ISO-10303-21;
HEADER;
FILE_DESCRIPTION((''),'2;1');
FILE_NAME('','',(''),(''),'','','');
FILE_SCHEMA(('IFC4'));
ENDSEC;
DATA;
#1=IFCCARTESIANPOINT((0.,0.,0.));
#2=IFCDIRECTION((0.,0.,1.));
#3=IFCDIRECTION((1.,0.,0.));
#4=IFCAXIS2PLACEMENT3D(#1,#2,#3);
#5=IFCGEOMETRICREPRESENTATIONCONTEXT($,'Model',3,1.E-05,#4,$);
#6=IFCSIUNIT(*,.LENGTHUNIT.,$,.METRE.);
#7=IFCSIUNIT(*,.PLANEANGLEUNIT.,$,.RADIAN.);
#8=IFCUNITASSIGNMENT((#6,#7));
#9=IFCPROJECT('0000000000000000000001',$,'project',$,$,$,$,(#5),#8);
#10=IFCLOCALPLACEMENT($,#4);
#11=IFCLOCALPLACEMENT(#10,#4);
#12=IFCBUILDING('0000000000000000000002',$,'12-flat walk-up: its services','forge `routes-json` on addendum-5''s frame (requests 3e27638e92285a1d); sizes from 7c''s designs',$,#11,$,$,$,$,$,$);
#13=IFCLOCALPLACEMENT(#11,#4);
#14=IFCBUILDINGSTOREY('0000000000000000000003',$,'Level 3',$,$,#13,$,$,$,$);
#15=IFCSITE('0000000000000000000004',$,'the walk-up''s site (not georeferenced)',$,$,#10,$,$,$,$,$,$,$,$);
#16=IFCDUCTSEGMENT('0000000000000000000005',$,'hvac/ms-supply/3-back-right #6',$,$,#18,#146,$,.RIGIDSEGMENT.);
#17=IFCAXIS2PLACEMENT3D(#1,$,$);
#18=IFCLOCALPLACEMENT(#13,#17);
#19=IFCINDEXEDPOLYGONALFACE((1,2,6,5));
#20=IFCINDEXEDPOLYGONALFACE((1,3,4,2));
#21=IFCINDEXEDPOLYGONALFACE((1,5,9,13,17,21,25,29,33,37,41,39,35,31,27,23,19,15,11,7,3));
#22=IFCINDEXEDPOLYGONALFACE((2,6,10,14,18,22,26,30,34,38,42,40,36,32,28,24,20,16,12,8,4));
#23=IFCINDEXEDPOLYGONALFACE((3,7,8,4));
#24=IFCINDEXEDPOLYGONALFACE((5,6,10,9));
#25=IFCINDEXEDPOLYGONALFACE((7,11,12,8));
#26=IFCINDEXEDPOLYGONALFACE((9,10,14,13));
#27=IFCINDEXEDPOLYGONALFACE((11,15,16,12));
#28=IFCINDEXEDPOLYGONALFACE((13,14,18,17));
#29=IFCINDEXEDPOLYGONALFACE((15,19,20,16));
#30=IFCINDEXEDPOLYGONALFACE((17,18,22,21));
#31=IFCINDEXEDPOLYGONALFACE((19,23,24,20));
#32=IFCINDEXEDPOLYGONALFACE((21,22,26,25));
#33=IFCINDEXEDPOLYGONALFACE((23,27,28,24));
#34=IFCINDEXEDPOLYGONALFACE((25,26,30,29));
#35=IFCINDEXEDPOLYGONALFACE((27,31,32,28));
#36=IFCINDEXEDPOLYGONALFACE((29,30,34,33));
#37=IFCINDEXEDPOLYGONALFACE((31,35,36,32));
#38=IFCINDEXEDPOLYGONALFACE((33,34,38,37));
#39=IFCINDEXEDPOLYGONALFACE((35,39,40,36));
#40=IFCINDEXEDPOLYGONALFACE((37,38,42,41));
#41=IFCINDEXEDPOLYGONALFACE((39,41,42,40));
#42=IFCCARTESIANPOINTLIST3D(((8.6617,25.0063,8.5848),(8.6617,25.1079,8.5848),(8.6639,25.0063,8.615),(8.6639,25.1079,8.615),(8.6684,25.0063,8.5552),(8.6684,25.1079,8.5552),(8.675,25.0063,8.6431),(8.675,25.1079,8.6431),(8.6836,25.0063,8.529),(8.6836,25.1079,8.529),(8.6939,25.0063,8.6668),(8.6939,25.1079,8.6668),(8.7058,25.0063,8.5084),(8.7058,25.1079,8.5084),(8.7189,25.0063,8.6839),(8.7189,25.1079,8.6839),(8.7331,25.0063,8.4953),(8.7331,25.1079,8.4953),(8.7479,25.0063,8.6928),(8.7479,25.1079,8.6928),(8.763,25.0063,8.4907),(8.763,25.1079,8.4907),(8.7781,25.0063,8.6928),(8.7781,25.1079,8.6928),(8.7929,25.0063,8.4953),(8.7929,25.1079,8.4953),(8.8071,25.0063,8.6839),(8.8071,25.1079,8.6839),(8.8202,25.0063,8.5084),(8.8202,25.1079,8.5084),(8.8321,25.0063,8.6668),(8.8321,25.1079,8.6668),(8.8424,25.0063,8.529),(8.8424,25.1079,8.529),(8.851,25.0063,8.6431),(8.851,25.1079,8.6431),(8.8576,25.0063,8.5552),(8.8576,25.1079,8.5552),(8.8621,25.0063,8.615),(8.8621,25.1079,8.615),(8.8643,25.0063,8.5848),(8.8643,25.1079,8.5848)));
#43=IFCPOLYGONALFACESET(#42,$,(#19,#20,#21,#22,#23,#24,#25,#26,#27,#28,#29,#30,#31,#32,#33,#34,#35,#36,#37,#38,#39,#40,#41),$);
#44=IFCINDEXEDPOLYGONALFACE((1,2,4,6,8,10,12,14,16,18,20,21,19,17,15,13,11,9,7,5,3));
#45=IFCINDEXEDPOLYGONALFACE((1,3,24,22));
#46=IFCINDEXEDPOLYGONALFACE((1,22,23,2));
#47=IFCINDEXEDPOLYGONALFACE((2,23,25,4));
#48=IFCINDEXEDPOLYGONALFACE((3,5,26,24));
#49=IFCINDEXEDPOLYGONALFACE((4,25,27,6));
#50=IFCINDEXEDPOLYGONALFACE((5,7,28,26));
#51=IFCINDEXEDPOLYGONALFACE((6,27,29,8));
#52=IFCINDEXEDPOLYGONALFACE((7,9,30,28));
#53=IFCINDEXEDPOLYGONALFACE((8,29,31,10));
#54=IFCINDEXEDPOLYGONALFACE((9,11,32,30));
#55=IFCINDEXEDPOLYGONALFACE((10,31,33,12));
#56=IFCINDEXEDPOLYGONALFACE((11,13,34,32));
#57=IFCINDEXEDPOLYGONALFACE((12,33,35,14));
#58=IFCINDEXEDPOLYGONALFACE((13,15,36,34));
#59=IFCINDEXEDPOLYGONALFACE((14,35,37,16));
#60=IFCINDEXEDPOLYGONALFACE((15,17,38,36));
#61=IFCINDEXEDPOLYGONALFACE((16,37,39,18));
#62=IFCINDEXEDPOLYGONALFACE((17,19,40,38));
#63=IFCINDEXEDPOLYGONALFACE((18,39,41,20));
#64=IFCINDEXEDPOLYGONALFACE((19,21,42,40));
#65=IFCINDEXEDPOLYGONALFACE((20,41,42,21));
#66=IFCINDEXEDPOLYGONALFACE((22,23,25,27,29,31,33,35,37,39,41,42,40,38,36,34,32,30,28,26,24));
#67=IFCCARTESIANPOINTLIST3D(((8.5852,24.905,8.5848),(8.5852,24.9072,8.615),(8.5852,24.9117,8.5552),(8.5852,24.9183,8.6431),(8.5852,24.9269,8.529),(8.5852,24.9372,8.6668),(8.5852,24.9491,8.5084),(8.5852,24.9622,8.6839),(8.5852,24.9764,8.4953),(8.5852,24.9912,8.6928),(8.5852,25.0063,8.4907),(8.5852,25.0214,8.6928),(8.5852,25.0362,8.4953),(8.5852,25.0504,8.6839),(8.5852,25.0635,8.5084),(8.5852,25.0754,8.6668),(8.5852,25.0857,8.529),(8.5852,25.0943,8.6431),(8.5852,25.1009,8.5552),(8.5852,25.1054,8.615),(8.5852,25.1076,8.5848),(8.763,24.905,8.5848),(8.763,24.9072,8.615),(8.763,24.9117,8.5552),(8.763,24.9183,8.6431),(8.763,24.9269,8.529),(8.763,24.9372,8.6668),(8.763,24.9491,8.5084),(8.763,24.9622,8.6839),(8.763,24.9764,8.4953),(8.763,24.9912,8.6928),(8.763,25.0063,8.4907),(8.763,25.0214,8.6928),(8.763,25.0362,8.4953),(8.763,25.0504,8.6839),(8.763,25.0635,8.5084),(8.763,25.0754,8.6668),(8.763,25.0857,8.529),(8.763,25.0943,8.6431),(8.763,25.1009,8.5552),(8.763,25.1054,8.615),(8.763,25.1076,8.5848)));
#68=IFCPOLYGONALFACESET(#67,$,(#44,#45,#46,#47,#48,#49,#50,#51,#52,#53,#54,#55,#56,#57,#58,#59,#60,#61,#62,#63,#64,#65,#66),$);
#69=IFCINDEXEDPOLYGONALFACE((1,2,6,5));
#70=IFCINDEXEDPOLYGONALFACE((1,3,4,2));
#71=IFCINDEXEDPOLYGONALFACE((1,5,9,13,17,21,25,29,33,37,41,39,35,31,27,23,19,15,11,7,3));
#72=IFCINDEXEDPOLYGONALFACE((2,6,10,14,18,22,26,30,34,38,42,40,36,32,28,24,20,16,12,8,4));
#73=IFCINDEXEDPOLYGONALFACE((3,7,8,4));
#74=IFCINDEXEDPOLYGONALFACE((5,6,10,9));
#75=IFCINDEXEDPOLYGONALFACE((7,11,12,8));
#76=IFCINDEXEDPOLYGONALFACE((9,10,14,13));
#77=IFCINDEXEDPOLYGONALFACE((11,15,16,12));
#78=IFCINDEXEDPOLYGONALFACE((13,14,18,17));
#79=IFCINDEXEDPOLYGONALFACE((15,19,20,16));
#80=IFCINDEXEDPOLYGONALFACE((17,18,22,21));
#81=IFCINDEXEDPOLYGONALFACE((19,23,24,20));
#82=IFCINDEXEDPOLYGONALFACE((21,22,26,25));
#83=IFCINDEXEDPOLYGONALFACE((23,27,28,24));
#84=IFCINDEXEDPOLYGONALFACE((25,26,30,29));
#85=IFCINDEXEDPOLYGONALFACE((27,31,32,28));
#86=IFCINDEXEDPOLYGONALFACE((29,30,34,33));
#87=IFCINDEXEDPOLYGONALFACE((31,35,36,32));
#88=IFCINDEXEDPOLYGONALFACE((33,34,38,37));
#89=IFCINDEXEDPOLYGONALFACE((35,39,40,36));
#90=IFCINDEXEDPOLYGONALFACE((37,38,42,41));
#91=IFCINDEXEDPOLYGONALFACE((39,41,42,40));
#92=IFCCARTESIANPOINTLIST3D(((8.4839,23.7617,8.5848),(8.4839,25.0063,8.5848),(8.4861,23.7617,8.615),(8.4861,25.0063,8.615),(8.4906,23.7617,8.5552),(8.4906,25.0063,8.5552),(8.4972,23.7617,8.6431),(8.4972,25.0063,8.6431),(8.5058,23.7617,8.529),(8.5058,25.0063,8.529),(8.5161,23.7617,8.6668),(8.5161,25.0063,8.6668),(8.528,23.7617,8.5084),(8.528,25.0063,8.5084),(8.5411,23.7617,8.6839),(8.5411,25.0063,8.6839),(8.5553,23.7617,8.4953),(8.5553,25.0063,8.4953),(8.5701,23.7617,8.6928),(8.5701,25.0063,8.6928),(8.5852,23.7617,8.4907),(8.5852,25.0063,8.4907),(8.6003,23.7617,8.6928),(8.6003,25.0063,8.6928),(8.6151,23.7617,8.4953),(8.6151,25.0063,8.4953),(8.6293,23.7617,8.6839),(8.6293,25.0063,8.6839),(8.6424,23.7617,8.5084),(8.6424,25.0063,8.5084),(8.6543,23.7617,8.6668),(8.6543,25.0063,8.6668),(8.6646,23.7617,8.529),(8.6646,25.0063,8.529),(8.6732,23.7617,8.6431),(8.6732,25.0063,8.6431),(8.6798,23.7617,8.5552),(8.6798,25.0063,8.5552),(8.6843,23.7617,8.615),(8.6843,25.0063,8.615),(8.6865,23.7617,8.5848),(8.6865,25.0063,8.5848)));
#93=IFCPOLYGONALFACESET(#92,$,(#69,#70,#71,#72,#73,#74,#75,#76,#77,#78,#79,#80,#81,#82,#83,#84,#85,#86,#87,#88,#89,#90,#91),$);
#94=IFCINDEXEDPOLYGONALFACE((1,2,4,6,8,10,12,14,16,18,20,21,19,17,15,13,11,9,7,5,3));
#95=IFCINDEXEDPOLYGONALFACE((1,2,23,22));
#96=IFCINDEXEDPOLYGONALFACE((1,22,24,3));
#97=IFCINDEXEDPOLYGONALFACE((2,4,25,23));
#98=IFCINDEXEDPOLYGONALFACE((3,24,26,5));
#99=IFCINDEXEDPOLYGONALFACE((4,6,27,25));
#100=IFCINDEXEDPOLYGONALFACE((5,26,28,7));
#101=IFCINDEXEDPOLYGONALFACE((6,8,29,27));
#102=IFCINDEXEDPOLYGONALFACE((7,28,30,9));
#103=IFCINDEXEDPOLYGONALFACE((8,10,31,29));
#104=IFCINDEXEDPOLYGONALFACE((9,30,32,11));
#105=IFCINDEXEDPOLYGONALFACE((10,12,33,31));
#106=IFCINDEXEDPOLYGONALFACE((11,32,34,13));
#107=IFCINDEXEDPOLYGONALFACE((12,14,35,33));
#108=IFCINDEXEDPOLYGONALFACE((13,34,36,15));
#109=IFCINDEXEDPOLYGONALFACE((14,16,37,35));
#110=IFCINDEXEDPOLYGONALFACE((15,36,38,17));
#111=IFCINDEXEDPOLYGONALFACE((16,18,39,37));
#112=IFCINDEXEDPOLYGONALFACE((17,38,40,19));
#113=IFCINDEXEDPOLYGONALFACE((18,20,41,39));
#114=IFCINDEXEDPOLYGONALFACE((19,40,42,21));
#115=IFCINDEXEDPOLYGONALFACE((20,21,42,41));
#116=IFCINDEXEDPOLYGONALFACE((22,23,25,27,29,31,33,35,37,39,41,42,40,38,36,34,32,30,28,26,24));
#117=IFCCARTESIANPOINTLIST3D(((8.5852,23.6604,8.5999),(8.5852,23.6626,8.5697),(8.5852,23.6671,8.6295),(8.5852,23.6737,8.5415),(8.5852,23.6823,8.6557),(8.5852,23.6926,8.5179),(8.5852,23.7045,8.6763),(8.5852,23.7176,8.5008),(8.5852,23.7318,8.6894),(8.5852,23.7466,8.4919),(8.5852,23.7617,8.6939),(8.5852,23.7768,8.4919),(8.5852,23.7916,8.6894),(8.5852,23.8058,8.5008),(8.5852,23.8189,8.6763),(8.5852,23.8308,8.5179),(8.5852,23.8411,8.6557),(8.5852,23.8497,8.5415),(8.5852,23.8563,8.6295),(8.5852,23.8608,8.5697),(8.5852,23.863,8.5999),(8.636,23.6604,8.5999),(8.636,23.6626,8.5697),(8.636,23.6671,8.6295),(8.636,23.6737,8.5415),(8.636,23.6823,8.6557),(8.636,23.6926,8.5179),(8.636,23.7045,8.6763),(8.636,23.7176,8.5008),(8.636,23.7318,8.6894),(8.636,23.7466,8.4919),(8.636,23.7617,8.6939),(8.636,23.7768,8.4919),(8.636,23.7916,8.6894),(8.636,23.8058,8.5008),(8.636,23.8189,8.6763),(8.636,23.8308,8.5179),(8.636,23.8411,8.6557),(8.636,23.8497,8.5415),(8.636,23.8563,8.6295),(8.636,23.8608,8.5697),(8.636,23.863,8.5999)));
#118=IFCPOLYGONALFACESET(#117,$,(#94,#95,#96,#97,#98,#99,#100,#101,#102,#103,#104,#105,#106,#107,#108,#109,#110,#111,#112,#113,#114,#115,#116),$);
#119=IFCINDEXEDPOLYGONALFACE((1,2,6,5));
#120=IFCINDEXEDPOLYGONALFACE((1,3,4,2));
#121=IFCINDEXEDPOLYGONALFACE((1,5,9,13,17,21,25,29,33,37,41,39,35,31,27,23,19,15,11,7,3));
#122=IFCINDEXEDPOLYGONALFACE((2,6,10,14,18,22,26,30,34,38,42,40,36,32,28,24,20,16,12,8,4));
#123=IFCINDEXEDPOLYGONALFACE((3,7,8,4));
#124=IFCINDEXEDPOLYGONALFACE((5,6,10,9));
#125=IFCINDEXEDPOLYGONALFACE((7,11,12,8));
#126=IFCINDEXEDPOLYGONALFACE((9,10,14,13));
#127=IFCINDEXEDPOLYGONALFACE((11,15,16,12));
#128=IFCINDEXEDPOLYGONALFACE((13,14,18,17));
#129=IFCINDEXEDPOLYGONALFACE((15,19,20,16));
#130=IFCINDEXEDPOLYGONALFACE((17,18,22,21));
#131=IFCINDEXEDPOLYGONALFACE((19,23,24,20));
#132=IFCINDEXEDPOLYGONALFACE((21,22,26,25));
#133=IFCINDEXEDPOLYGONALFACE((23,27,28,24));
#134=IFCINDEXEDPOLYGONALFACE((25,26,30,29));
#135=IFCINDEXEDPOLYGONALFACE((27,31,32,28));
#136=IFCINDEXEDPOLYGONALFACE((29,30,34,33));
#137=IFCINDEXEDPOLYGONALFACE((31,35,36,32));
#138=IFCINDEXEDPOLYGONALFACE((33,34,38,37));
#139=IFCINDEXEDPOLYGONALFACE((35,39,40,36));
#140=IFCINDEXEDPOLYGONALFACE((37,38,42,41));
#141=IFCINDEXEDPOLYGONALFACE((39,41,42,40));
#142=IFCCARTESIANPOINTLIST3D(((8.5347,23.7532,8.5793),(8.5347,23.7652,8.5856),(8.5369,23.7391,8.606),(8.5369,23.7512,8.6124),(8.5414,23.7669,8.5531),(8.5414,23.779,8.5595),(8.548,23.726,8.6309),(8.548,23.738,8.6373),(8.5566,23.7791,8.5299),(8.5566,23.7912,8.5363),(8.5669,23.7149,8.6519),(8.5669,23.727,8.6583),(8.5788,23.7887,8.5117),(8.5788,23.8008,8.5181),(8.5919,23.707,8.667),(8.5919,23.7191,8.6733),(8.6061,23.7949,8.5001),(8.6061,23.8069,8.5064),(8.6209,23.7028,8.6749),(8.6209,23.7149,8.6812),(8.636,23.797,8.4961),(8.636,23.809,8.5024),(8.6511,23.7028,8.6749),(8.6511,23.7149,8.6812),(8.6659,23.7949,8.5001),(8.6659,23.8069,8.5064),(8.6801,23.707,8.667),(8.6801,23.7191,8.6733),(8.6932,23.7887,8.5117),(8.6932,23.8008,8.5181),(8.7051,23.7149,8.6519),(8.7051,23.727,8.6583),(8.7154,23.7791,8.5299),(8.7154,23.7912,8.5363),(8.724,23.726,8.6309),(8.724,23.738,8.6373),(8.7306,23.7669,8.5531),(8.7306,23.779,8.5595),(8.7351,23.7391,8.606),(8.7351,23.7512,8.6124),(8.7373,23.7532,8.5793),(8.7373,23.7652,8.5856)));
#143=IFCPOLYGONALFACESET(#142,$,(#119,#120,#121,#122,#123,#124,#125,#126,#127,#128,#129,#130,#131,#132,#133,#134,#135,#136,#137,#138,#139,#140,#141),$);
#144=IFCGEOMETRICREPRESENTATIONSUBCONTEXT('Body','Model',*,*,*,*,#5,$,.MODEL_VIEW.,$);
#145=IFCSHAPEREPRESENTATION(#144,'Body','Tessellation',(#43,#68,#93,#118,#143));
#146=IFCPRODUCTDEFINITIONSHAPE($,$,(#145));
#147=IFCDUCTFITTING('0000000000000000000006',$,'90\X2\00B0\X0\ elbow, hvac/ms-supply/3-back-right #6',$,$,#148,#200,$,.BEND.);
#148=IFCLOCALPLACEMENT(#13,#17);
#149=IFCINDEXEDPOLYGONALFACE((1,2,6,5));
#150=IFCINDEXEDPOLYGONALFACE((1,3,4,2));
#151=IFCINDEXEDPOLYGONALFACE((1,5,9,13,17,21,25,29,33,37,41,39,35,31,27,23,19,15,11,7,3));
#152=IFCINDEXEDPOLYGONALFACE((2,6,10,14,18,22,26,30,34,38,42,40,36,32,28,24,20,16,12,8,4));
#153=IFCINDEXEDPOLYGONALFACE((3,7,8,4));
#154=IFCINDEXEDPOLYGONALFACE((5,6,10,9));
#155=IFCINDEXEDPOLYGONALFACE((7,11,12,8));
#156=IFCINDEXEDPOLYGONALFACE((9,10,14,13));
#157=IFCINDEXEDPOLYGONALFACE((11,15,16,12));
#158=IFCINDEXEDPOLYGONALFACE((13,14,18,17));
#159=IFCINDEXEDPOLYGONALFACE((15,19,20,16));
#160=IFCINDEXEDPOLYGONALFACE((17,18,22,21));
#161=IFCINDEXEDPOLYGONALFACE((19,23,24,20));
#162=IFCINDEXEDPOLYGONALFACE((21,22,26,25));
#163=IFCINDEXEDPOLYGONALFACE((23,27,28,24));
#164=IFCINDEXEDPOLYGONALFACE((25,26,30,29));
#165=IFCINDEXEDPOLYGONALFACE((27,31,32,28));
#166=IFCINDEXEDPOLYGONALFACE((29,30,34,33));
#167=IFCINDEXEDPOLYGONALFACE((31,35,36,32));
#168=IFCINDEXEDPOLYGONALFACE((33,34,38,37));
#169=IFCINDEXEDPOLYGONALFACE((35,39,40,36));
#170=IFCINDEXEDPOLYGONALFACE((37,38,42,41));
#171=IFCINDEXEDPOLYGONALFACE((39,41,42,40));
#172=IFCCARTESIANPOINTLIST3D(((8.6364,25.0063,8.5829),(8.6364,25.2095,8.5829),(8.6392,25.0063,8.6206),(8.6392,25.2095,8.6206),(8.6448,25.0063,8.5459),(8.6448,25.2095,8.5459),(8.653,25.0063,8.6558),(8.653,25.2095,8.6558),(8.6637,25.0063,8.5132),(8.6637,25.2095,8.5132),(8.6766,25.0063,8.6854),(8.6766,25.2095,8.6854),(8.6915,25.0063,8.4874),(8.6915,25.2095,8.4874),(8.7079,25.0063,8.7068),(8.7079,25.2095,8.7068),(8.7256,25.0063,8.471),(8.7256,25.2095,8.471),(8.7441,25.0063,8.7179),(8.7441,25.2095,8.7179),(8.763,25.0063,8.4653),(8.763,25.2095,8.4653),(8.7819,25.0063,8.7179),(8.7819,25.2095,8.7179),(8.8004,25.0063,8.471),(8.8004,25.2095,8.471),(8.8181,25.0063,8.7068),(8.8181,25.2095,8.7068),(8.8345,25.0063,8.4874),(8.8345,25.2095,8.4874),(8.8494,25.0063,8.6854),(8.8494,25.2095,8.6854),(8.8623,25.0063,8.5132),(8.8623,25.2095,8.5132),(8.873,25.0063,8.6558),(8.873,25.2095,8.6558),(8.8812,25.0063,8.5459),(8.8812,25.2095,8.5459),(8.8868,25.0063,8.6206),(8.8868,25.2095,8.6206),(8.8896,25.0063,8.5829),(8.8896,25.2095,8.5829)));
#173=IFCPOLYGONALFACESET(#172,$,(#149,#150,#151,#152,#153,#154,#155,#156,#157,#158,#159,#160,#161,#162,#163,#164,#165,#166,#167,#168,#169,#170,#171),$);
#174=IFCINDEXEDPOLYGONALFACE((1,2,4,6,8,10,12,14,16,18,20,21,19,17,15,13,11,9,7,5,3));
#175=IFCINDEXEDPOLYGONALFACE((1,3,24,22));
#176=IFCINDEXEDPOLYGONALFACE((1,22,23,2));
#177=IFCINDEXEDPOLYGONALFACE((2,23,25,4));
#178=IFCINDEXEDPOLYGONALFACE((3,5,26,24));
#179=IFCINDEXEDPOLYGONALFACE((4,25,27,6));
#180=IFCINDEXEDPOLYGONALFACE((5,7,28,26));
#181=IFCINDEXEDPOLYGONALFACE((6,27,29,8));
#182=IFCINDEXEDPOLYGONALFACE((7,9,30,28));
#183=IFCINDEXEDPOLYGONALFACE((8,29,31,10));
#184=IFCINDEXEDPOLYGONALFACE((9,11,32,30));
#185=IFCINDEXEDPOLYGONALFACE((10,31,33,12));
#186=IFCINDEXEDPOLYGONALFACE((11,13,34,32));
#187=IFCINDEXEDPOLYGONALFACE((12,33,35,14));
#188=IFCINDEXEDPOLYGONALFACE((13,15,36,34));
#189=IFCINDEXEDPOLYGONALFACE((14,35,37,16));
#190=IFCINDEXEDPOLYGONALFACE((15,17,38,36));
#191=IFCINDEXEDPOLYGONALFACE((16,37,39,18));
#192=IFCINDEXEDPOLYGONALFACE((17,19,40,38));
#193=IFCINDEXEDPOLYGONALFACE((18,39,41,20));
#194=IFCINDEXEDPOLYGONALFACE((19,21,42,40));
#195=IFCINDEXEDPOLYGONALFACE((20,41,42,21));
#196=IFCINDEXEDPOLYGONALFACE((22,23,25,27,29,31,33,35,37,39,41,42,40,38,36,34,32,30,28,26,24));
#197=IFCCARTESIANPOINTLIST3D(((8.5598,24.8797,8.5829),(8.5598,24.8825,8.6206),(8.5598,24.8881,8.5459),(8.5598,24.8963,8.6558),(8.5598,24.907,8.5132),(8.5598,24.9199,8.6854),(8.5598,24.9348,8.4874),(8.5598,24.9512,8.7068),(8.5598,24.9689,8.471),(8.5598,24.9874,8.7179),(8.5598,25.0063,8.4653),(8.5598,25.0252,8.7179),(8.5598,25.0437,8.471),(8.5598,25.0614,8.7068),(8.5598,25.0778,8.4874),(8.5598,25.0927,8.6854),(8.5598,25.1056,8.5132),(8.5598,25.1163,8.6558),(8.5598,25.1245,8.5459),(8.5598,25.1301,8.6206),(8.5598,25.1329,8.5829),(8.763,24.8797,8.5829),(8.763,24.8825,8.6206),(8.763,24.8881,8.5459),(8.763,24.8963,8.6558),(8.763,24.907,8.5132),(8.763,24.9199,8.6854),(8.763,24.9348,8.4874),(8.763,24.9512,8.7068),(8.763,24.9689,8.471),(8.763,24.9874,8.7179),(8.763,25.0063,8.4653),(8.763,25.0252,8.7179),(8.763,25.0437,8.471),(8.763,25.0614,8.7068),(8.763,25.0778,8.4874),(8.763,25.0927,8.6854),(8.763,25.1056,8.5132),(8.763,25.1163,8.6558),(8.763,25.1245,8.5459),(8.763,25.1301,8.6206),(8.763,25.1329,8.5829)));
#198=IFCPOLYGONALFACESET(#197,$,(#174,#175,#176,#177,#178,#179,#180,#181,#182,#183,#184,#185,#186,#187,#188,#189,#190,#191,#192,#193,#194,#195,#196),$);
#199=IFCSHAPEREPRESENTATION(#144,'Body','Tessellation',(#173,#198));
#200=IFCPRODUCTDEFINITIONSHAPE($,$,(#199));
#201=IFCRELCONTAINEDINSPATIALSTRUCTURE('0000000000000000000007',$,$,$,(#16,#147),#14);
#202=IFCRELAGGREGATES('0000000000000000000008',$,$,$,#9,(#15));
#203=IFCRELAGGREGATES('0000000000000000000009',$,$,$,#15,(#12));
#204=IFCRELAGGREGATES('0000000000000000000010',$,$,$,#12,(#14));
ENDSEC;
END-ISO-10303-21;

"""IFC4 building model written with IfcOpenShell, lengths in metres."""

from ifc_helpers import new_model, entity, si_unit, frame, origin_with_axes, place, context, subcontext, project, spatial, element, save


model = new_model("IFC4")

# Units and contexts
model_context = context("Model", 3, precision=1e-05, world=origin_with_axes())
body_context = subcontext(model_context, "Body", "Model", "MODEL_VIEW")
ifc_project = project(units=[si_unit("LENGTHUNIT", "METRE"), si_unit("PLANEANGLEUNIT", "RADIAN")], contexts=[model_context])

# Site, building, storey
site_placement = place(None, origin_with_axes())
site = spatial("IfcSite", under=ifc_project, at=site_placement, Name="the walk-up's site (not georeferenced)")
building_placement = place(site_placement, origin_with_axes())
building = spatial("IfcBuilding", under=site, at=building_placement, Name="12-flat walk-up: its services", Description="forge `routes-json` on addendum-5's frame (requests 3e27638e92285a1d); sizes from 7c's designs")
storey_placement = place(building_placement, origin_with_axes())
storey = spatial("IfcBuildingStorey", under=building, at=storey_placement, Name="Level 3")

# Duct segment
duct_segment_1_placement = place(storey_placement, frame((8.763, 25.1079, 8.5923), z_axis=(0.0, 0.0, 1.0), x_axis=(1.0, 0.0, 0.0)))
element("IfcDuctSegment", 1, at=duct_segment_1_placement, inside=storey, Name="hvac/ms-supply/3-back-right #6", PredefinedType="RIGIDSEGMENT", context=body_context, shape_type="AdvancedSweptSolid", body=[
    entity("IfcSweptDiskSolid", entity("IfcPolyline", [entity("IfcCartesianPoint", [0.0, 0.0, 0.0]), entity("IfcCartesianPoint", [0.0, -0.1016, 0.0])]), 0.1016),
    entity("IfcSweptDiskSolid", entity("IfcPolyline", [entity("IfcCartesianPoint", [0.0, -0.1016, 0.0]), entity("IfcCartesianPoint", [-0.1778, -0.1016, 0.0])]), 0.1016),
    entity("IfcSweptDiskSolid", entity("IfcPolyline", [entity("IfcCartesianPoint", [-0.1778, -0.1016, 0.0]), entity("IfcCartesianPoint", [-0.1778, -1.3462, 0.0])]), 0.1016),
    entity("IfcSweptDiskSolid", entity("IfcPolyline", [entity("IfcCartesianPoint", [-0.1778, -1.3462, 0.0]), entity("IfcCartesianPoint", [-0.127, -1.3462, 0.0])]), 0.1016),
    entity("IfcSweptDiskSolid", entity("IfcPolyline", [entity("IfcCartesianPoint", [-0.127, -1.3462, 0.0]), entity("IfcCartesianPoint", [-0.127, -1.3583, -0.0063])]), 0.1016),
])

# Duct fitting
duct_fitting_1_placement = place(storey_placement, frame((8.763, 25.2095, 8.5923), z_axis=(0.0, 0.0, 1.0), x_axis=(1.0, 0.0, 0.0)))
element("IfcDuctFitting", 2, at=duct_fitting_1_placement, inside=storey, Name="90° elbow, hvac/ms-supply/3-back-right #6", PredefinedType="BEND", context=body_context, shape_type="AdvancedSweptSolid", body=[
    entity("IfcSweptDiskSolid", entity("IfcPolyline", [entity("IfcCartesianPoint", [0.0, 0.0, 0.0]), entity("IfcCartesianPoint", [0.0, -0.2032, 0.0])]), 0.127),
    entity("IfcSweptDiskSolid", entity("IfcPolyline", [entity("IfcCartesianPoint", [0.0, -0.2032, 0.0]), entity("IfcCartesianPoint", [-0.2032, -0.2032, 0.0])]), 0.127),
])

save(model, "model.ifc")
